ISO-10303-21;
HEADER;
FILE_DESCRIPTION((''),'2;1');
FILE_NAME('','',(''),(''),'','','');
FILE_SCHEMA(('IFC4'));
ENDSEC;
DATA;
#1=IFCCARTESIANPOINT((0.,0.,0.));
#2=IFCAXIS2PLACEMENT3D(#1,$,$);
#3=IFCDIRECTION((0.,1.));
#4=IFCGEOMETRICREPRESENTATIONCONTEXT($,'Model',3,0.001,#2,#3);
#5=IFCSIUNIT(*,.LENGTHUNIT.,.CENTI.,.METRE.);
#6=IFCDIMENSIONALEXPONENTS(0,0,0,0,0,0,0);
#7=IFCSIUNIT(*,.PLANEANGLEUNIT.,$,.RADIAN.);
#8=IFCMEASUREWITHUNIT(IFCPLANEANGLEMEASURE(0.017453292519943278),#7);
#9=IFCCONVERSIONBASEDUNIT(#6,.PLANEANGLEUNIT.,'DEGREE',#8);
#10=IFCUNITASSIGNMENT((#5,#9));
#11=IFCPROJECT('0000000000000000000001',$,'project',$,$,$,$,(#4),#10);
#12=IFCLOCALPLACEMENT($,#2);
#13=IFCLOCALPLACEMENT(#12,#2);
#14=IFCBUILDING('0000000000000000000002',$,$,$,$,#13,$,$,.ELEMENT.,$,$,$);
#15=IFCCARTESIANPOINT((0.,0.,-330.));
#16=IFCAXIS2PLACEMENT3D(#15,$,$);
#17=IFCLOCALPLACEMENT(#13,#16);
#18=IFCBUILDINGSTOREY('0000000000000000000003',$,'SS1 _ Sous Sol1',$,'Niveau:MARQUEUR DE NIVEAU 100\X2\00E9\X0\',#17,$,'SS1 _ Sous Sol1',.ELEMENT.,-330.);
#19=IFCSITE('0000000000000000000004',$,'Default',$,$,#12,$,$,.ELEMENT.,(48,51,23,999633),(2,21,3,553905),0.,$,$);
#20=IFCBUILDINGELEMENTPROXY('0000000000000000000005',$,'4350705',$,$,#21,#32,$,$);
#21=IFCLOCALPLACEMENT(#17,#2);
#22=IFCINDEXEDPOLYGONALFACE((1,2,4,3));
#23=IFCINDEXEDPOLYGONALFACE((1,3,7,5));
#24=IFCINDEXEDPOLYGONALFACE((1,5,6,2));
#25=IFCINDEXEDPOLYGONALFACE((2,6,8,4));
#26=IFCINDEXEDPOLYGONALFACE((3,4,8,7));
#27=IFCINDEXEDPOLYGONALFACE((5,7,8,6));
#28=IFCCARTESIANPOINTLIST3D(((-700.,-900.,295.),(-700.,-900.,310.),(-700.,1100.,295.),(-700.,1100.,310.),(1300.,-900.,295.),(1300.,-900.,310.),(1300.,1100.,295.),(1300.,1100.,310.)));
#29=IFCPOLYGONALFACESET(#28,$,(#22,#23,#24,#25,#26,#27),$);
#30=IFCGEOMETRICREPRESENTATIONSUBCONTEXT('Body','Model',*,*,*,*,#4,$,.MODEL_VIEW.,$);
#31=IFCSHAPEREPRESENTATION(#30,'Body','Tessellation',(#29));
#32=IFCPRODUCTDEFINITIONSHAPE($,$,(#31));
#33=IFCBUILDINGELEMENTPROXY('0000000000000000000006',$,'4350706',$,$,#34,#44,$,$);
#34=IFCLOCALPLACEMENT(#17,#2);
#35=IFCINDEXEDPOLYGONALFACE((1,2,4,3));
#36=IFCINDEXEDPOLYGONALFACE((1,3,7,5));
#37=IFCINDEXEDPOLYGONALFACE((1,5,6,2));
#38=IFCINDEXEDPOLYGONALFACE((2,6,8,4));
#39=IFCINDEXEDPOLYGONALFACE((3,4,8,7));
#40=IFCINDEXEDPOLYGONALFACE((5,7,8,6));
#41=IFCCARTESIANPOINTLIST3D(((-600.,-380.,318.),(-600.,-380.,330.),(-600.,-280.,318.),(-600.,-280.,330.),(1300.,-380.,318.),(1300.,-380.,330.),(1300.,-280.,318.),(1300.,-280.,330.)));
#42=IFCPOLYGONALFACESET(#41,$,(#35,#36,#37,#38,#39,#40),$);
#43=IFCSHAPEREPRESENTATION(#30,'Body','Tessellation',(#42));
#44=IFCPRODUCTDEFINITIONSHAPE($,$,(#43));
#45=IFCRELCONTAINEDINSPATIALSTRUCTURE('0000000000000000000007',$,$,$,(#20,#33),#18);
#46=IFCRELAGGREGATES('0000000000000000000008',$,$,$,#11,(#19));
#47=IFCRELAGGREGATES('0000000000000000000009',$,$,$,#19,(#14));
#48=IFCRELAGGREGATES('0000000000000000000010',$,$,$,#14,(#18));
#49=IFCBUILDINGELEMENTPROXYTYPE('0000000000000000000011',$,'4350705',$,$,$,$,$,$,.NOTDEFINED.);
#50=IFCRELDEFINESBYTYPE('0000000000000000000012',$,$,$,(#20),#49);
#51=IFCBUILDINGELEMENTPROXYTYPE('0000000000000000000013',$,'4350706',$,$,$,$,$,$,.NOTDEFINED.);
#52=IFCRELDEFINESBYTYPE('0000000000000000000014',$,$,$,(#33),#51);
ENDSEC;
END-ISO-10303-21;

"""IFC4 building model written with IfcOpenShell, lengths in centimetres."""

from ifc_helpers import new_model, entity, si_unit, converted_unit, direction, frame, frame_2d, origin, origin_2d_with_axis, place, context, subcontext, project, spatial, rectangle, extrude, type_object, element, save


model = new_model("IFC4")

# Units and contexts
model_context = context("Model", 3, precision=0.001, world=origin(), true_north=direction((0.0, 1.0)))
body_context = subcontext(model_context, "Body", "Model", "MODEL_VIEW")
ifc_project = project(units=[si_unit("LENGTHUNIT", "METRE", prefix="CENTI"), converted_unit("PLANEANGLEUNIT", "DEGREE", entity("IfcPlaneAngleMeasure", 0.017453292519943278), si_unit("PLANEANGLEUNIT", "RADIAN"), dimensions=[0, 0, 0, 0, 0, 0, 0])], contexts=[model_context])

# Site, building, storey
site_placement = place(None, origin())
site = spatial("IfcSite", under=ifc_project, at=site_placement, Name="Default", CompositionType="ELEMENT", RefLatitude=(48, 51, 23, 999633), RefLongitude=(2, 21, 3, 553905), RefElevation=0.0)
building_placement = place(site_placement, origin())
building = spatial("IfcBuilding", under=site, at=building_placement, CompositionType="ELEMENT")
storey_placement = place(building_placement, frame((0.0, 0.0, -330.0)))
storey = spatial("IfcBuildingStorey", under=building, at=storey_placement, Name="SS1 _ Sous Sol1", ObjectType="Niveau:MARQUEUR DE NIVEAU 100é", LongName="SS1 _ Sous Sol1", CompositionType="ELEMENT", Elevation=-330.0)

# Building element proxies
building_element_proxy_type_1 = type_object("IfcBuildingElementProxyType", Name="4350705", PredefinedType="NOTDEFINED")
proxy_1_placement = place(storey_placement, origin())
element("IfcBuildingElementProxy", 1, at=proxy_1_placement, inside=storey, type_object=building_element_proxy_type_1, Name="4350705", context=body_context, shape_type="SweptSolid", body=[
    extrude(rectangle(XDim=2000.0, YDim=2000.0, at=frame_2d((0.0, 0.0), x_axis=(1.0, 0.0))), frame((300.0, 100.0, 295.0)), (0.0, 0.0, 1.0), 15.0),
])
building_element_proxy_type_2 = type_object("IfcBuildingElementProxyType", Name="4350706", PredefinedType="NOTDEFINED")
proxy_2_placement = place(storey_placement, origin())
element("IfcBuildingElementProxy", 2, at=proxy_2_placement, inside=storey, type_object=building_element_proxy_type_2, Name="4350706", context=body_context, shape_type="SweptSolid", body=[
    extrude(rectangle(XDim=1900.0, YDim=100.0, at=origin_2d_with_axis()), frame((350.0, -330.0, 318.0)), (0.0, 0.0, 1.0), 12.0),
])

save(model, "model.ifc")
